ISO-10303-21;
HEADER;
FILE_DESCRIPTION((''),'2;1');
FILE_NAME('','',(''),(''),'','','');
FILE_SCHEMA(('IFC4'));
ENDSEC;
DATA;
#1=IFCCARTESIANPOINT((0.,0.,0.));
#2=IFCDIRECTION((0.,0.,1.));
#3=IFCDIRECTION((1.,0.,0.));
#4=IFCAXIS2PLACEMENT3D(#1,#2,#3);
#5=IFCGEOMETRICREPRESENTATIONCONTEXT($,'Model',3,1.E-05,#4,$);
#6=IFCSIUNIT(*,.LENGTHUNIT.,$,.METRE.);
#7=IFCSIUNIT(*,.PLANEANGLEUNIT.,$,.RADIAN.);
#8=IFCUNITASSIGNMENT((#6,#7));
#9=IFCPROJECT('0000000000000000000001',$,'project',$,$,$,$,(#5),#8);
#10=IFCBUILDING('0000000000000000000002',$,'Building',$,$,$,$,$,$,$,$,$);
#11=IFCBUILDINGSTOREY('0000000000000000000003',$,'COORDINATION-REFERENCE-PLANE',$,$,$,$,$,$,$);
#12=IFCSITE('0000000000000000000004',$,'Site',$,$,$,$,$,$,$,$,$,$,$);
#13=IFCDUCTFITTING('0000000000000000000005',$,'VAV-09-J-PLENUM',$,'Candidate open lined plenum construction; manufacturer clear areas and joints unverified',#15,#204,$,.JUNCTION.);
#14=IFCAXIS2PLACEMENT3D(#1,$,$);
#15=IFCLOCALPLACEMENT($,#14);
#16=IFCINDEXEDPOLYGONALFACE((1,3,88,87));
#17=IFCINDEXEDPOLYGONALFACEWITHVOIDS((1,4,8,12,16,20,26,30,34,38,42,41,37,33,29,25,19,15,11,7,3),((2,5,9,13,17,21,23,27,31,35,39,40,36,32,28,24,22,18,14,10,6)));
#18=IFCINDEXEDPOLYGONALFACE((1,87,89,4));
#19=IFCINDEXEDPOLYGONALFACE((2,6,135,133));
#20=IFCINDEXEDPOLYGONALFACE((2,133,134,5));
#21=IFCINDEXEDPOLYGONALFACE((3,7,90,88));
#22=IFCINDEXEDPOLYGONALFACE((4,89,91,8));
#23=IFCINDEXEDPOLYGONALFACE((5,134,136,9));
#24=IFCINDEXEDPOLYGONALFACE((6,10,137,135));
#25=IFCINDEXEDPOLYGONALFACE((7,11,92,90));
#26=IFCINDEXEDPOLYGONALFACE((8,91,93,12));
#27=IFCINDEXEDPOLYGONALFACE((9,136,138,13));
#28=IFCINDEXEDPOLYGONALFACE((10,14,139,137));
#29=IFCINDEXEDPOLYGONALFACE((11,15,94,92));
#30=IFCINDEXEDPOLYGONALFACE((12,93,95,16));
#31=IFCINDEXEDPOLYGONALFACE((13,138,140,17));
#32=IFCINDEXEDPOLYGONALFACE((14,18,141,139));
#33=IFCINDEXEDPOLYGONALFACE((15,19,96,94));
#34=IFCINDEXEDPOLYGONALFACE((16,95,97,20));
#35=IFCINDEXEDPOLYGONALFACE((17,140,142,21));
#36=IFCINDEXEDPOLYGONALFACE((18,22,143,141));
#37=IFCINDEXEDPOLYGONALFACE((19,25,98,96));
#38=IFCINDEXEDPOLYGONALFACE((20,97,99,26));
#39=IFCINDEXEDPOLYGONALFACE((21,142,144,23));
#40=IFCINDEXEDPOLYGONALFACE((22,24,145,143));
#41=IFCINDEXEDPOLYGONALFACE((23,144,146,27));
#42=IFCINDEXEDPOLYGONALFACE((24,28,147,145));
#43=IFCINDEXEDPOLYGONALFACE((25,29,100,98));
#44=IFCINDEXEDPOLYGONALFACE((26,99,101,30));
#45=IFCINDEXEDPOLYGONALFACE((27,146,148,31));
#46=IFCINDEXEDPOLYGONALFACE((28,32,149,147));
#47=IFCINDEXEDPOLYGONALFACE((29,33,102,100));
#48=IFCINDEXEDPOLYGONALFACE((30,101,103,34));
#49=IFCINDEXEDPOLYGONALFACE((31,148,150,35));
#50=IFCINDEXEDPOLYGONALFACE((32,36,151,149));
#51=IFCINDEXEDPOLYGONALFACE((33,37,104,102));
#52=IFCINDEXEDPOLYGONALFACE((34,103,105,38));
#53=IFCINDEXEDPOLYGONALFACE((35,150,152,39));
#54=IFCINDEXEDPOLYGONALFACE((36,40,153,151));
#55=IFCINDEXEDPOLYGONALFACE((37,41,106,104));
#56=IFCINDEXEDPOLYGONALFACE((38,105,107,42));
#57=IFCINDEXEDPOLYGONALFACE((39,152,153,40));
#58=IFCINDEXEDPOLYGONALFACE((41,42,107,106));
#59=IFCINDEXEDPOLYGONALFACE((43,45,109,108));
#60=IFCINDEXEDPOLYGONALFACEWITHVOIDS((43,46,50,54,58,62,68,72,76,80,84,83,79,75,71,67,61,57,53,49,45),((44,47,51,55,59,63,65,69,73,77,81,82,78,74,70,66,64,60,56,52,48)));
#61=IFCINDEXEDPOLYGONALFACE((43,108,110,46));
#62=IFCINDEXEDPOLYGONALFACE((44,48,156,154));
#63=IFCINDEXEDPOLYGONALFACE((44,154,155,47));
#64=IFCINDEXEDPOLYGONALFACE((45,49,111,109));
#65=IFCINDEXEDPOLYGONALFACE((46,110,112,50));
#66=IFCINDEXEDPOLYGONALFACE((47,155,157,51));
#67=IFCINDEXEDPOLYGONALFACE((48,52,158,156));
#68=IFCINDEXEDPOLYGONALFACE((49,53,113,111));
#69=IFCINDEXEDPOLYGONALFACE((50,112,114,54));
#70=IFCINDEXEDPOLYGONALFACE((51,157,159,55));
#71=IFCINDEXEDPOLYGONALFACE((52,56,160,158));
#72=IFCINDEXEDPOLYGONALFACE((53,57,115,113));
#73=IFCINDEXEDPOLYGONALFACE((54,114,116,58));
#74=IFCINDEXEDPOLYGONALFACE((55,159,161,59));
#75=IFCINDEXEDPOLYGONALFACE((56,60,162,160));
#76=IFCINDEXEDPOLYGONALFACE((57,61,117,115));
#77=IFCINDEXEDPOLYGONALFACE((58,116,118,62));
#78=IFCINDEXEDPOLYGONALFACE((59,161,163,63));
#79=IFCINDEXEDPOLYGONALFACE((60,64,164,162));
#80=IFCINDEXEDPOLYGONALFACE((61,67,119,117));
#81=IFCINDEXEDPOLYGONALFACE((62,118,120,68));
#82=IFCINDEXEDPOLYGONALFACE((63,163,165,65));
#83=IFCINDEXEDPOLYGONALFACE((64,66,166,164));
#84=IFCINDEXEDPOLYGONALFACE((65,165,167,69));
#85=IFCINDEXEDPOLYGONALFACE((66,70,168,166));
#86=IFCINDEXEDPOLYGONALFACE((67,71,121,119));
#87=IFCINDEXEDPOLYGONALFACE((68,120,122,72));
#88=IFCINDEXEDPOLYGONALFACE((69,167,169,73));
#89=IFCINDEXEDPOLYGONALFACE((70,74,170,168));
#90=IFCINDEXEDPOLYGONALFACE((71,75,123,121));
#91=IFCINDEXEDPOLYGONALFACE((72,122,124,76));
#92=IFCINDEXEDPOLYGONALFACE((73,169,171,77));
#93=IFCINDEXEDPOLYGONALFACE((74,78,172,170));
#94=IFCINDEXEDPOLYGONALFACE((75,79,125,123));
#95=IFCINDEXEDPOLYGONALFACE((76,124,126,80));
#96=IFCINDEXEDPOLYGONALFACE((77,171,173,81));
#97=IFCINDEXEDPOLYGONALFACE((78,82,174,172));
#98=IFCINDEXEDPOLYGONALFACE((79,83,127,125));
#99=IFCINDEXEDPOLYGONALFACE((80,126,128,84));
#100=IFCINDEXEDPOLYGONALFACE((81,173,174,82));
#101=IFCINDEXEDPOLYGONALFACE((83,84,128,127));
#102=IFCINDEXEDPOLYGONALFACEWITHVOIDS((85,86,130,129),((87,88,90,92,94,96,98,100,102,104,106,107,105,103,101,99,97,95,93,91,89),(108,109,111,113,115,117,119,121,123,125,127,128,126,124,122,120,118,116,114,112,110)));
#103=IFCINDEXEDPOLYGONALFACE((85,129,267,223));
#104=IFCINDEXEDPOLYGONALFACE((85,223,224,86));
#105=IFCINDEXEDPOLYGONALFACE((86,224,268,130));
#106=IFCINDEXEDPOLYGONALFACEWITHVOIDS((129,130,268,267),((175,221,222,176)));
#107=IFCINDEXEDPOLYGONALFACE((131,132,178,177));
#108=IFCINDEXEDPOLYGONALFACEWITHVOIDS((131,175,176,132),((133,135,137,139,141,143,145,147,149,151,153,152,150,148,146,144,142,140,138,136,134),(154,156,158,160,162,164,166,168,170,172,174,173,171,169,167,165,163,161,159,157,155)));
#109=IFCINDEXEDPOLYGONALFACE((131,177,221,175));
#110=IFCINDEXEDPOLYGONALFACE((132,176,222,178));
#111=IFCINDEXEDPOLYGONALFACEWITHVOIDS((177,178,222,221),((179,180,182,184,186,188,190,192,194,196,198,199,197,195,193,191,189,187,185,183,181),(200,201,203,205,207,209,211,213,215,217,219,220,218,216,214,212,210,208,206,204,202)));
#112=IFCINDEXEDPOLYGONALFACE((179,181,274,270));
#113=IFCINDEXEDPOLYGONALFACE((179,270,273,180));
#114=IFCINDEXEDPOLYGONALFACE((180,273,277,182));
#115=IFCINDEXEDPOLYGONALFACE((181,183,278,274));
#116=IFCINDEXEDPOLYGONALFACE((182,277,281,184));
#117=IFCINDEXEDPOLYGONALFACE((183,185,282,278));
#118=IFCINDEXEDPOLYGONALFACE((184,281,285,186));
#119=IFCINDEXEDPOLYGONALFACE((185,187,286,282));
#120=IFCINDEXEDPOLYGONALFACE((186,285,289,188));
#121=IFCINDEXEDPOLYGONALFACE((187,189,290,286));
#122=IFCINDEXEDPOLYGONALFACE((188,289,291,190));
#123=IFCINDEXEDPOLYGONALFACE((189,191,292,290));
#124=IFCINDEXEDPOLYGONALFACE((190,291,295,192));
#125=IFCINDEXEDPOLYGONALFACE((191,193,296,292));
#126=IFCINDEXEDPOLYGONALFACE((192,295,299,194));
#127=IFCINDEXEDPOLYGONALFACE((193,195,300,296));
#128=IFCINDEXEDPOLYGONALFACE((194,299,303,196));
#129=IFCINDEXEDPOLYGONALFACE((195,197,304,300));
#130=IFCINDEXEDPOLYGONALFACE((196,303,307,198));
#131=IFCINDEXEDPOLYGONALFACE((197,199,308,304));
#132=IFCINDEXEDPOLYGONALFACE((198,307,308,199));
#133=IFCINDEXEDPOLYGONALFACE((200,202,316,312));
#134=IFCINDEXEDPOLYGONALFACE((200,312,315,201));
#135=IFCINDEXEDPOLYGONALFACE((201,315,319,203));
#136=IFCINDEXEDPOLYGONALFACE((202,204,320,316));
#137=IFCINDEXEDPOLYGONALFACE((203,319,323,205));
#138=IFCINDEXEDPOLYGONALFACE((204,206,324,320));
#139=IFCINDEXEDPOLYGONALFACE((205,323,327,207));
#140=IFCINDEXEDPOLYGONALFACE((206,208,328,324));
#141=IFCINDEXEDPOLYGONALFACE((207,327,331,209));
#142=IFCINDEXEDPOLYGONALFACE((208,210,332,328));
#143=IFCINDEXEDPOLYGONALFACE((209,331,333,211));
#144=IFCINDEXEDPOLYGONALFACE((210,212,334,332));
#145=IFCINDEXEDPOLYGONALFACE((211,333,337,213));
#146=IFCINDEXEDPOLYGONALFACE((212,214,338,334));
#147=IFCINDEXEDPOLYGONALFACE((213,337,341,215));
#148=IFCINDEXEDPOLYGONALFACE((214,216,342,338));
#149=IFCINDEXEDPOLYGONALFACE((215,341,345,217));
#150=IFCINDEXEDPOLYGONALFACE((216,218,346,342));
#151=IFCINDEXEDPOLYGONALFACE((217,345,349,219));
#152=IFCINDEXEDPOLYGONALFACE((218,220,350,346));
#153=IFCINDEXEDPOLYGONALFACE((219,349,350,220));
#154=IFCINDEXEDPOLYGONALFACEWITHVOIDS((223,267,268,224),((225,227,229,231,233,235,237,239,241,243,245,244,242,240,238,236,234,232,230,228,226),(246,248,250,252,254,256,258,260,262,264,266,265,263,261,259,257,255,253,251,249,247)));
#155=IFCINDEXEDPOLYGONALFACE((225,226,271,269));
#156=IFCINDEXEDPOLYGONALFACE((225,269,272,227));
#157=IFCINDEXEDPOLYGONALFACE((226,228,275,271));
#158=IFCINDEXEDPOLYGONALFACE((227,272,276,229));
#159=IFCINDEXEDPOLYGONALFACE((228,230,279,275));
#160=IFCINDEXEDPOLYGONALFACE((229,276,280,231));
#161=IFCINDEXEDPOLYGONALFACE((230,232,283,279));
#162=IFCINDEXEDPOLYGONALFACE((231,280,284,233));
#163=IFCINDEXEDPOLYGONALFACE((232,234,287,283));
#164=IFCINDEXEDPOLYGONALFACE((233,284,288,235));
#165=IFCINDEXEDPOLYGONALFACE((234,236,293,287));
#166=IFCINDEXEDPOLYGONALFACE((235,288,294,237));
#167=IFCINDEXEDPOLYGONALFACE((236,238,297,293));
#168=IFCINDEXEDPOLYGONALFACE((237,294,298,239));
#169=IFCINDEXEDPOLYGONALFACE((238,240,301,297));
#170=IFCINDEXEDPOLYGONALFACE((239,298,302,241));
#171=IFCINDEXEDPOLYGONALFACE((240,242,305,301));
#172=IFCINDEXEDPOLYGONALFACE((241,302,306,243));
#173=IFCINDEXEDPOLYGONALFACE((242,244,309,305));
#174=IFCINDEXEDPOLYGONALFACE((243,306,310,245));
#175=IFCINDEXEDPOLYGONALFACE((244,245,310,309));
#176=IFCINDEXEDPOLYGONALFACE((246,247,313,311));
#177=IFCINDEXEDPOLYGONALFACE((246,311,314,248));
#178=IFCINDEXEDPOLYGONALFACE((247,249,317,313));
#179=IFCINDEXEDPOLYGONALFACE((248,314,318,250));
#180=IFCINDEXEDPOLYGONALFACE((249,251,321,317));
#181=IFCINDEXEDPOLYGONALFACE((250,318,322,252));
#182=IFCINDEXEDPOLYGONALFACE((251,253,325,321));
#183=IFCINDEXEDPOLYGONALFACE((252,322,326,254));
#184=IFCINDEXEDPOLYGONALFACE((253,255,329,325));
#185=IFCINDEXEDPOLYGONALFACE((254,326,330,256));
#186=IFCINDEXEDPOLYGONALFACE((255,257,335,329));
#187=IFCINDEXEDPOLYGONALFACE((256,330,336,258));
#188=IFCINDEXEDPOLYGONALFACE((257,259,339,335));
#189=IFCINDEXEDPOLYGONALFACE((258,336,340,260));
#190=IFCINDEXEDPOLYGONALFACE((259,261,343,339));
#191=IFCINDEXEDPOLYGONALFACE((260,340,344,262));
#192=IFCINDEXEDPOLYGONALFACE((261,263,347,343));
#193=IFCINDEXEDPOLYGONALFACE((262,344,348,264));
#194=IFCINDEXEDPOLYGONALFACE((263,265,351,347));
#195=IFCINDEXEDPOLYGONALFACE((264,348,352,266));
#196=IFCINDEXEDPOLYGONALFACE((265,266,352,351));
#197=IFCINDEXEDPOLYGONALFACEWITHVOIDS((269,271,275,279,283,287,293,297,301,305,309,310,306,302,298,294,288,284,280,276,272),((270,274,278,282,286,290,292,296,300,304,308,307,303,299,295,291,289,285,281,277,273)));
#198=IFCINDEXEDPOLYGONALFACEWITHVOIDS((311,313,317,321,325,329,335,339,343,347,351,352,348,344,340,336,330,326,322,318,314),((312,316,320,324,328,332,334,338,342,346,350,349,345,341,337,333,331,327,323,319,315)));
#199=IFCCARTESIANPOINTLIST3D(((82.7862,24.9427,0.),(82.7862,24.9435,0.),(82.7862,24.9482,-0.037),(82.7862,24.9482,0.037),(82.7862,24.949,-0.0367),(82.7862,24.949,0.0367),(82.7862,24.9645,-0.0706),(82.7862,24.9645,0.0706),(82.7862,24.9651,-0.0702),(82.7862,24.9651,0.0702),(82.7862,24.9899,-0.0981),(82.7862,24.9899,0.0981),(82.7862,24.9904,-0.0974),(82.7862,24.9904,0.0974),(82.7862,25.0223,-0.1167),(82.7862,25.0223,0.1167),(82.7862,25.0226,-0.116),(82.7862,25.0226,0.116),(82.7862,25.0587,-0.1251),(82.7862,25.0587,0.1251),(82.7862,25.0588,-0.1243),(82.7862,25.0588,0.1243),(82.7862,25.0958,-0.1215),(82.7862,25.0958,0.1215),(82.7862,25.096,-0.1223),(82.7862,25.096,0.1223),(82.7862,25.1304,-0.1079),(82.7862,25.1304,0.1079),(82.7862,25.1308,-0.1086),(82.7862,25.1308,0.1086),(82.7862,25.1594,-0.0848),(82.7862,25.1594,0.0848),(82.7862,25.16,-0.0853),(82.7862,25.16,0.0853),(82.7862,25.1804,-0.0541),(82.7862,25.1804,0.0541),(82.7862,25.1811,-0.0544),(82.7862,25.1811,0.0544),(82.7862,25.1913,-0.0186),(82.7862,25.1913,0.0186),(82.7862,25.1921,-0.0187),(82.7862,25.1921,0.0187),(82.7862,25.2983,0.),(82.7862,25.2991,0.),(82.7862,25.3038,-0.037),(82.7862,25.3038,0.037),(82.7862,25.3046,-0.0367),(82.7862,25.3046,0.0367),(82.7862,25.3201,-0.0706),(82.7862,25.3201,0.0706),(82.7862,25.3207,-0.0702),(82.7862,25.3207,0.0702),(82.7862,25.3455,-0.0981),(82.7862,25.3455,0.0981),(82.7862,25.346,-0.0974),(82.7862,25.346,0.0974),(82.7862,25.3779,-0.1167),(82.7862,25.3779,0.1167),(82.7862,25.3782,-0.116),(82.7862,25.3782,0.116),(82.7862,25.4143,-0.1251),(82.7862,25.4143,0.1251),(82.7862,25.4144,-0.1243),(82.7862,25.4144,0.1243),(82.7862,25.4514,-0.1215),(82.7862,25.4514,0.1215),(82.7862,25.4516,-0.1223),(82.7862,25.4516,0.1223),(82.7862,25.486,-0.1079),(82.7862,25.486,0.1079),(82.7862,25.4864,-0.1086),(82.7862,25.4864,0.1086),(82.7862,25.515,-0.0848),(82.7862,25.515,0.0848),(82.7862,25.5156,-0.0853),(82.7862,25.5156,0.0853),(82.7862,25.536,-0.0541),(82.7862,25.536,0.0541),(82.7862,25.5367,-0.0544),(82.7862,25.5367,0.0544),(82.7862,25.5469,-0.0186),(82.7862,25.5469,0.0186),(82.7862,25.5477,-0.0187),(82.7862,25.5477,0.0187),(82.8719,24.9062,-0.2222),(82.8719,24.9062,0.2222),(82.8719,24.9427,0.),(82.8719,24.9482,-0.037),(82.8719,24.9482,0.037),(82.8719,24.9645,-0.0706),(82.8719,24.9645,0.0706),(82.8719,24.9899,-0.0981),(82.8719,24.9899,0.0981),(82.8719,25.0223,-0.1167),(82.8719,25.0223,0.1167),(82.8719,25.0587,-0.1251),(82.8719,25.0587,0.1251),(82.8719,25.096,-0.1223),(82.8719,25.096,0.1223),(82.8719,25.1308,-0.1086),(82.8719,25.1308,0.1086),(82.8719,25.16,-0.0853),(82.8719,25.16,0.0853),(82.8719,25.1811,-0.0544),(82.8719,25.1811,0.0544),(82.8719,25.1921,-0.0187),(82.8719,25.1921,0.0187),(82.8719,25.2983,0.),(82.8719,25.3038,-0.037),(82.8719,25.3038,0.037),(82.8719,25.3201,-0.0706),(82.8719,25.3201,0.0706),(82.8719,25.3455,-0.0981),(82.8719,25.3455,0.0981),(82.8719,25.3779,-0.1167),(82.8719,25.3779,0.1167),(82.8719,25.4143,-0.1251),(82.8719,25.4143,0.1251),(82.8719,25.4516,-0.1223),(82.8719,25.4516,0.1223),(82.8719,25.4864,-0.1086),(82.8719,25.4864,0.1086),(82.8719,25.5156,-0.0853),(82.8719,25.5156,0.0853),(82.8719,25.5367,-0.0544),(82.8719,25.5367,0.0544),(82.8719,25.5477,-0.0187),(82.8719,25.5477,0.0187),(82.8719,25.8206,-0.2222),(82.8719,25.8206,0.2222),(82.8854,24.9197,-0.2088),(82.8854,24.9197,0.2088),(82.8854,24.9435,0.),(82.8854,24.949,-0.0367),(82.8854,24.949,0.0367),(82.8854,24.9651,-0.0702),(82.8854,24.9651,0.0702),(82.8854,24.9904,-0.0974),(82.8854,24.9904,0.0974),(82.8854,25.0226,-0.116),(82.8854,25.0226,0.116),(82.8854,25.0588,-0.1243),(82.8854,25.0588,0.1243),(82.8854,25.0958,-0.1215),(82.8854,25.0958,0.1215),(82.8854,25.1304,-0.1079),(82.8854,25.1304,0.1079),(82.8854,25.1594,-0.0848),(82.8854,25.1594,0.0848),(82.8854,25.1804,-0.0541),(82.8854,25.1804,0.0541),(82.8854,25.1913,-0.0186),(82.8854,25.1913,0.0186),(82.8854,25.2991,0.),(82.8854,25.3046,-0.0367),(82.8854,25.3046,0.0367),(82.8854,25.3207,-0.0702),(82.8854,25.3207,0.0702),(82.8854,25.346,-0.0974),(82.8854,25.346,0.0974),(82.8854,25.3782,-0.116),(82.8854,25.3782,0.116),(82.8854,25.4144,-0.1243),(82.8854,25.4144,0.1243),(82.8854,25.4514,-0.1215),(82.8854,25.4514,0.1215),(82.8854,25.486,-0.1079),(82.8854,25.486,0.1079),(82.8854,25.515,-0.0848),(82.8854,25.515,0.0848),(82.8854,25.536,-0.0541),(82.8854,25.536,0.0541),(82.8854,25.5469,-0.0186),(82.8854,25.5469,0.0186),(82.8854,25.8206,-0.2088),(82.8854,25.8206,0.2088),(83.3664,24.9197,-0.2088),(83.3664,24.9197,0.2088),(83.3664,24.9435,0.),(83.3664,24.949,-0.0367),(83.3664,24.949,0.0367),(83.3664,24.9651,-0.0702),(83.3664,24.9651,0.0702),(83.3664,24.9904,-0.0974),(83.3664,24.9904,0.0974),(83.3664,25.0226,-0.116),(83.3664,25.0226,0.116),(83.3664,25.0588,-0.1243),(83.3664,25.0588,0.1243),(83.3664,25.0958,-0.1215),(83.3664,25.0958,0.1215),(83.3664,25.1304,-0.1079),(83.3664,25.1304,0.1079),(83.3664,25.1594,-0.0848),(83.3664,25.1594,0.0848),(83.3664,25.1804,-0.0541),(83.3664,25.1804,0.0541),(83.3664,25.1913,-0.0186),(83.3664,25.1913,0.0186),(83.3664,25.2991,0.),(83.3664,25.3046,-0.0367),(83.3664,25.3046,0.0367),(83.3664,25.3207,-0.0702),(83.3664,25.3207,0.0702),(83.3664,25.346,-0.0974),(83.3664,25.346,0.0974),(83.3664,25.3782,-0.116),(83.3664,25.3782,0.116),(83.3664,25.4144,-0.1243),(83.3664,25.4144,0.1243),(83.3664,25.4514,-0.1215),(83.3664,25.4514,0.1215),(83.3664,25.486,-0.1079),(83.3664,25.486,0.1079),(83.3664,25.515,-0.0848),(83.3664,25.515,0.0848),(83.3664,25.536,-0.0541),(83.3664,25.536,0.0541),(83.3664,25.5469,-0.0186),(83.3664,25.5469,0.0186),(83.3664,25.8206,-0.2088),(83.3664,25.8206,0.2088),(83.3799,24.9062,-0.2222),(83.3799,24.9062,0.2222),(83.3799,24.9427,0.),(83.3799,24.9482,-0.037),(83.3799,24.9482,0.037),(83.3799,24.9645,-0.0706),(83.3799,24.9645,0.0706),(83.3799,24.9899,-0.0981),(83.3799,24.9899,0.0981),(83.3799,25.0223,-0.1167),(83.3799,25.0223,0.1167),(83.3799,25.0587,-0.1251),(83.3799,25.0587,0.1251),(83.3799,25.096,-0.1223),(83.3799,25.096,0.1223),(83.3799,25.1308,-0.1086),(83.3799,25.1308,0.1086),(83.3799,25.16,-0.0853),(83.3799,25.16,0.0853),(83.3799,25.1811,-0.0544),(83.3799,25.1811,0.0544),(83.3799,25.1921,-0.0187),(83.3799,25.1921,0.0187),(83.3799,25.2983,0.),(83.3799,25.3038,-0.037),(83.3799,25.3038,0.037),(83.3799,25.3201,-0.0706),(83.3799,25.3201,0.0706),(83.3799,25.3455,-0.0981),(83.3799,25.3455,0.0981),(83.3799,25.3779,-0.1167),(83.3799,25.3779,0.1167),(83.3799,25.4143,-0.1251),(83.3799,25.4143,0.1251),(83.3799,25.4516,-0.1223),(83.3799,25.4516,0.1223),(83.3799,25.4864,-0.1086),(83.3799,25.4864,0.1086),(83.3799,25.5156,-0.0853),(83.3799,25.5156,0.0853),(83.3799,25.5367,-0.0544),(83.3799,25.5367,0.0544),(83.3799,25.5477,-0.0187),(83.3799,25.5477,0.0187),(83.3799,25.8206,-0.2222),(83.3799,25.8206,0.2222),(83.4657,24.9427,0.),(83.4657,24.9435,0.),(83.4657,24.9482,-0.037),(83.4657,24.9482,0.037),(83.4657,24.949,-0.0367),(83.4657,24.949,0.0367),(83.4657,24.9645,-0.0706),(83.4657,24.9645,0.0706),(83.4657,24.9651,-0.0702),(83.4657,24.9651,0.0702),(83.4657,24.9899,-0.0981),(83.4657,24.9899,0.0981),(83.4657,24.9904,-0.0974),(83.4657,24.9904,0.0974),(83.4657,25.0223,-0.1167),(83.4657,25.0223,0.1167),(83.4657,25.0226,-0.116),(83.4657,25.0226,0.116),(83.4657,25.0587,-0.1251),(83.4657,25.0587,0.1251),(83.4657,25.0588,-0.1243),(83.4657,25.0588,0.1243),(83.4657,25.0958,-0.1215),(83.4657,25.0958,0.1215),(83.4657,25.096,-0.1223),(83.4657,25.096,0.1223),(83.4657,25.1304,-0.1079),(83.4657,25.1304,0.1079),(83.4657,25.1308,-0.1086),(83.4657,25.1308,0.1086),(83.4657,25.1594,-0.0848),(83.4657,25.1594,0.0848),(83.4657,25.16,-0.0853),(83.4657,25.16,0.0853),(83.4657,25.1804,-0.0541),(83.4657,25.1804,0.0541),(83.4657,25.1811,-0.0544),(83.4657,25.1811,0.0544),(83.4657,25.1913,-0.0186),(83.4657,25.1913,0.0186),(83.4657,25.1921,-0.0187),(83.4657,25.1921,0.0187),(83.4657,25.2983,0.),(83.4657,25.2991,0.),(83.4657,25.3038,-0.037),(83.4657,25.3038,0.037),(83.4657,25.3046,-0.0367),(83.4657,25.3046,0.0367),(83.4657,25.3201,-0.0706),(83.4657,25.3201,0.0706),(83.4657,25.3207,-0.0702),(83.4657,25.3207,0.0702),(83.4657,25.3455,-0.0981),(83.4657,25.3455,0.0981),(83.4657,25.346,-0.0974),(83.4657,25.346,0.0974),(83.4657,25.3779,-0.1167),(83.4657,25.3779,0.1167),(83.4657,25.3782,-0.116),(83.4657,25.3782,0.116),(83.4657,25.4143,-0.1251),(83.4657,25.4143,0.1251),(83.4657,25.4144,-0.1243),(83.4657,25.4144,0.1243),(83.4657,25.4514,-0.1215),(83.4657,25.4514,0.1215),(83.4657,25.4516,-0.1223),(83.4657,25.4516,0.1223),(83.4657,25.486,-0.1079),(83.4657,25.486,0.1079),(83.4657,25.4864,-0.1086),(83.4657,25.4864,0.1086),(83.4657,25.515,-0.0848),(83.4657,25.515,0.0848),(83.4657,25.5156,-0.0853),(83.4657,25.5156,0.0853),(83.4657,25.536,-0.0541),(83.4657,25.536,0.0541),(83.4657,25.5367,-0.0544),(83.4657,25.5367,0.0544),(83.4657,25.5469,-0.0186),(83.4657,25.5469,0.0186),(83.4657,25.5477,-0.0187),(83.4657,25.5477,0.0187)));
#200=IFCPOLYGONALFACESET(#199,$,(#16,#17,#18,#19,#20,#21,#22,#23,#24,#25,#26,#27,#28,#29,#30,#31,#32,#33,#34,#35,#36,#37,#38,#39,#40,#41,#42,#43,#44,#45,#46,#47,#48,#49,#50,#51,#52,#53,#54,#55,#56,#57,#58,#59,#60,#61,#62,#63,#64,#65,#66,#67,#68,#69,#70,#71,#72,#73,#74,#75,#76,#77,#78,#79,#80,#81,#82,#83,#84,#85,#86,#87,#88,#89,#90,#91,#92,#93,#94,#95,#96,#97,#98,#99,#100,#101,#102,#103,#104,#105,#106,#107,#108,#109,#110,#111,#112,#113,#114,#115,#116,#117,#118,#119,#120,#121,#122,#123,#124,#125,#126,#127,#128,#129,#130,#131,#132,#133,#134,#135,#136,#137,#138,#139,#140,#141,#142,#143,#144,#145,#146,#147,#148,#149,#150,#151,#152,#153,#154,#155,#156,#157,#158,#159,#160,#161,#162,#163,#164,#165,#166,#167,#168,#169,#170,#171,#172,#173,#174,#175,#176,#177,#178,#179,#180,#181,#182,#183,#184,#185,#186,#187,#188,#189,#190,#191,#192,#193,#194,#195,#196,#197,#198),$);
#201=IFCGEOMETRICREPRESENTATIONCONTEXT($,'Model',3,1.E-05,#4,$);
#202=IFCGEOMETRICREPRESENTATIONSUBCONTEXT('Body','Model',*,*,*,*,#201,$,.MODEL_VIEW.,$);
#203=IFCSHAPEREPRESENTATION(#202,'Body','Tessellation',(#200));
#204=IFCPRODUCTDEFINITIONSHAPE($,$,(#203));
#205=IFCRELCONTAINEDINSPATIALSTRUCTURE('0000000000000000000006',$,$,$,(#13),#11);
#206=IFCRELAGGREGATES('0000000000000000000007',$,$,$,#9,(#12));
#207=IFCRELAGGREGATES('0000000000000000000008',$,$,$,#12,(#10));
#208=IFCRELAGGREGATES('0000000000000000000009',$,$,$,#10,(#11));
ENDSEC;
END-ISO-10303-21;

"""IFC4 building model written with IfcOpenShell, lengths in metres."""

from ifc_helpers import new_model, si_unit, frame, origin_with_axes, place, context, subcontext, project, spatial, rectangle, circle, extrude, boolean, element, save


model = new_model("IFC4")

# Units and contexts
model_context_1 = context("Model", 3, precision=1e-05, world=origin_with_axes())
model_context_2 = context("Model", 3, precision=1e-05, world=origin_with_axes())
body_context_1 = subcontext(model_context_2, "Body", "Model", "MODEL_VIEW")
ifc_project = project(units=[si_unit("LENGTHUNIT", "METRE"), si_unit("PLANEANGLEUNIT", "RADIAN")], contexts=[model_context_1])

# Site, building, storey
site = spatial("IfcSite", under=ifc_project, Name="Site")
building = spatial("IfcBuilding", under=site, Name="Building")
storey = spatial("IfcBuildingStorey", under=building, Name="COORDINATION-REFERENCE-PLANE")

# Duct fitting
duct_fitting_1_placement = place(None, frame((82.8719, 24.9062, -0.2223), z_axis=(0.0, 0.0, 1.0), x_axis=(1.0, 0.0, 0.0)))
solid_1 = boolean("UNION", boolean("UNION", boolean("UNION", boolean("UNION", extrude(rectangle(XDim=0.481, YDim=0.4175), frame((0.254, 0.9244, 0.2223), z_axis=(0.0, -1.0, 0.0), x_axis=(1.0, 0.0, 0.0)), (0.0, 0.0, 1.0), 0.9109), extrude(circle(Radius=0.1246), frame((0.0235, 0.5175, 0.2223), z_axis=(-1.0, 0.0, 0.0), x_axis=(0.0, -1.0, 0.0)), (0.0, 0.0, 1.0), 0.1192)), extrude(circle(Radius=0.1246), frame((0.4845, 0.5175, 0.2223), z_axis=(1.0, 0.0, 0.0), x_axis=(0.0, -1.0, 0.0)), (0.0, 0.0, 1.0), 0.1192)), extrude(circle(Radius=0.1246), frame((0.0235, 0.1619, 0.2223), z_axis=(-1.0, 0.0, 0.0), x_axis=(0.0, -1.0, 0.0)), (0.0, 0.0, 1.0), 0.1192)), extrude(circle(Radius=0.1246), frame((0.4845, 0.1619, 0.2223), z_axis=(1.0, 0.0, 0.0), x_axis=(0.0, -1.0, 0.0)), (0.0, 0.0, 1.0), 0.1192))
element("IfcDuctFitting", 1, at=duct_fitting_1_placement, inside=storey, Name="VAV-09-J-PLENUM", ObjectType="Candidate open lined plenum construction; manufacturer clear areas and joints unverified", PredefinedType="JUNCTION", context=body_context_1, shape_type="CSG", body=[
    boolean("DIFFERENCE", boolean("UNION", boolean("UNION", boolean("UNION", boolean("UNION", extrude(rectangle(XDim=0.508, YDim=0.4445), frame((0.254, 0.9144, 0.2223), z_axis=(0.0, -1.0, 0.0), x_axis=(1.0, 0.0, 0.0)), (0.0, 0.0, 1.0), 0.9144), extrude(circle(Radius=0.1254), frame((0.0235, 0.5175, 0.2223), z_axis=(-1.0, 0.0, 0.0), x_axis=(0.0, -1.0, 0.0)), (0.0, 0.0, 1.0), 0.1092)), extrude(circle(Radius=0.1254), frame((0.4845, 0.5175, 0.2223), z_axis=(1.0, 0.0, 0.0), x_axis=(0.0, -1.0, 0.0)), (0.0, 0.0, 1.0), 0.1092)), extrude(circle(Radius=0.1254), frame((0.0235, 0.1619, 0.2223), z_axis=(-1.0, 0.0, 0.0), x_axis=(0.0, -1.0, 0.0)), (0.0, 0.0, 1.0), 0.1092)), extrude(circle(Radius=0.1254), frame((0.4845, 0.1619, 0.2223), z_axis=(1.0, 0.0, 0.0), x_axis=(0.0, -1.0, 0.0)), (0.0, 0.0, 1.0), 0.1092)), solid_1),
])

save(model, "model.ifc")
